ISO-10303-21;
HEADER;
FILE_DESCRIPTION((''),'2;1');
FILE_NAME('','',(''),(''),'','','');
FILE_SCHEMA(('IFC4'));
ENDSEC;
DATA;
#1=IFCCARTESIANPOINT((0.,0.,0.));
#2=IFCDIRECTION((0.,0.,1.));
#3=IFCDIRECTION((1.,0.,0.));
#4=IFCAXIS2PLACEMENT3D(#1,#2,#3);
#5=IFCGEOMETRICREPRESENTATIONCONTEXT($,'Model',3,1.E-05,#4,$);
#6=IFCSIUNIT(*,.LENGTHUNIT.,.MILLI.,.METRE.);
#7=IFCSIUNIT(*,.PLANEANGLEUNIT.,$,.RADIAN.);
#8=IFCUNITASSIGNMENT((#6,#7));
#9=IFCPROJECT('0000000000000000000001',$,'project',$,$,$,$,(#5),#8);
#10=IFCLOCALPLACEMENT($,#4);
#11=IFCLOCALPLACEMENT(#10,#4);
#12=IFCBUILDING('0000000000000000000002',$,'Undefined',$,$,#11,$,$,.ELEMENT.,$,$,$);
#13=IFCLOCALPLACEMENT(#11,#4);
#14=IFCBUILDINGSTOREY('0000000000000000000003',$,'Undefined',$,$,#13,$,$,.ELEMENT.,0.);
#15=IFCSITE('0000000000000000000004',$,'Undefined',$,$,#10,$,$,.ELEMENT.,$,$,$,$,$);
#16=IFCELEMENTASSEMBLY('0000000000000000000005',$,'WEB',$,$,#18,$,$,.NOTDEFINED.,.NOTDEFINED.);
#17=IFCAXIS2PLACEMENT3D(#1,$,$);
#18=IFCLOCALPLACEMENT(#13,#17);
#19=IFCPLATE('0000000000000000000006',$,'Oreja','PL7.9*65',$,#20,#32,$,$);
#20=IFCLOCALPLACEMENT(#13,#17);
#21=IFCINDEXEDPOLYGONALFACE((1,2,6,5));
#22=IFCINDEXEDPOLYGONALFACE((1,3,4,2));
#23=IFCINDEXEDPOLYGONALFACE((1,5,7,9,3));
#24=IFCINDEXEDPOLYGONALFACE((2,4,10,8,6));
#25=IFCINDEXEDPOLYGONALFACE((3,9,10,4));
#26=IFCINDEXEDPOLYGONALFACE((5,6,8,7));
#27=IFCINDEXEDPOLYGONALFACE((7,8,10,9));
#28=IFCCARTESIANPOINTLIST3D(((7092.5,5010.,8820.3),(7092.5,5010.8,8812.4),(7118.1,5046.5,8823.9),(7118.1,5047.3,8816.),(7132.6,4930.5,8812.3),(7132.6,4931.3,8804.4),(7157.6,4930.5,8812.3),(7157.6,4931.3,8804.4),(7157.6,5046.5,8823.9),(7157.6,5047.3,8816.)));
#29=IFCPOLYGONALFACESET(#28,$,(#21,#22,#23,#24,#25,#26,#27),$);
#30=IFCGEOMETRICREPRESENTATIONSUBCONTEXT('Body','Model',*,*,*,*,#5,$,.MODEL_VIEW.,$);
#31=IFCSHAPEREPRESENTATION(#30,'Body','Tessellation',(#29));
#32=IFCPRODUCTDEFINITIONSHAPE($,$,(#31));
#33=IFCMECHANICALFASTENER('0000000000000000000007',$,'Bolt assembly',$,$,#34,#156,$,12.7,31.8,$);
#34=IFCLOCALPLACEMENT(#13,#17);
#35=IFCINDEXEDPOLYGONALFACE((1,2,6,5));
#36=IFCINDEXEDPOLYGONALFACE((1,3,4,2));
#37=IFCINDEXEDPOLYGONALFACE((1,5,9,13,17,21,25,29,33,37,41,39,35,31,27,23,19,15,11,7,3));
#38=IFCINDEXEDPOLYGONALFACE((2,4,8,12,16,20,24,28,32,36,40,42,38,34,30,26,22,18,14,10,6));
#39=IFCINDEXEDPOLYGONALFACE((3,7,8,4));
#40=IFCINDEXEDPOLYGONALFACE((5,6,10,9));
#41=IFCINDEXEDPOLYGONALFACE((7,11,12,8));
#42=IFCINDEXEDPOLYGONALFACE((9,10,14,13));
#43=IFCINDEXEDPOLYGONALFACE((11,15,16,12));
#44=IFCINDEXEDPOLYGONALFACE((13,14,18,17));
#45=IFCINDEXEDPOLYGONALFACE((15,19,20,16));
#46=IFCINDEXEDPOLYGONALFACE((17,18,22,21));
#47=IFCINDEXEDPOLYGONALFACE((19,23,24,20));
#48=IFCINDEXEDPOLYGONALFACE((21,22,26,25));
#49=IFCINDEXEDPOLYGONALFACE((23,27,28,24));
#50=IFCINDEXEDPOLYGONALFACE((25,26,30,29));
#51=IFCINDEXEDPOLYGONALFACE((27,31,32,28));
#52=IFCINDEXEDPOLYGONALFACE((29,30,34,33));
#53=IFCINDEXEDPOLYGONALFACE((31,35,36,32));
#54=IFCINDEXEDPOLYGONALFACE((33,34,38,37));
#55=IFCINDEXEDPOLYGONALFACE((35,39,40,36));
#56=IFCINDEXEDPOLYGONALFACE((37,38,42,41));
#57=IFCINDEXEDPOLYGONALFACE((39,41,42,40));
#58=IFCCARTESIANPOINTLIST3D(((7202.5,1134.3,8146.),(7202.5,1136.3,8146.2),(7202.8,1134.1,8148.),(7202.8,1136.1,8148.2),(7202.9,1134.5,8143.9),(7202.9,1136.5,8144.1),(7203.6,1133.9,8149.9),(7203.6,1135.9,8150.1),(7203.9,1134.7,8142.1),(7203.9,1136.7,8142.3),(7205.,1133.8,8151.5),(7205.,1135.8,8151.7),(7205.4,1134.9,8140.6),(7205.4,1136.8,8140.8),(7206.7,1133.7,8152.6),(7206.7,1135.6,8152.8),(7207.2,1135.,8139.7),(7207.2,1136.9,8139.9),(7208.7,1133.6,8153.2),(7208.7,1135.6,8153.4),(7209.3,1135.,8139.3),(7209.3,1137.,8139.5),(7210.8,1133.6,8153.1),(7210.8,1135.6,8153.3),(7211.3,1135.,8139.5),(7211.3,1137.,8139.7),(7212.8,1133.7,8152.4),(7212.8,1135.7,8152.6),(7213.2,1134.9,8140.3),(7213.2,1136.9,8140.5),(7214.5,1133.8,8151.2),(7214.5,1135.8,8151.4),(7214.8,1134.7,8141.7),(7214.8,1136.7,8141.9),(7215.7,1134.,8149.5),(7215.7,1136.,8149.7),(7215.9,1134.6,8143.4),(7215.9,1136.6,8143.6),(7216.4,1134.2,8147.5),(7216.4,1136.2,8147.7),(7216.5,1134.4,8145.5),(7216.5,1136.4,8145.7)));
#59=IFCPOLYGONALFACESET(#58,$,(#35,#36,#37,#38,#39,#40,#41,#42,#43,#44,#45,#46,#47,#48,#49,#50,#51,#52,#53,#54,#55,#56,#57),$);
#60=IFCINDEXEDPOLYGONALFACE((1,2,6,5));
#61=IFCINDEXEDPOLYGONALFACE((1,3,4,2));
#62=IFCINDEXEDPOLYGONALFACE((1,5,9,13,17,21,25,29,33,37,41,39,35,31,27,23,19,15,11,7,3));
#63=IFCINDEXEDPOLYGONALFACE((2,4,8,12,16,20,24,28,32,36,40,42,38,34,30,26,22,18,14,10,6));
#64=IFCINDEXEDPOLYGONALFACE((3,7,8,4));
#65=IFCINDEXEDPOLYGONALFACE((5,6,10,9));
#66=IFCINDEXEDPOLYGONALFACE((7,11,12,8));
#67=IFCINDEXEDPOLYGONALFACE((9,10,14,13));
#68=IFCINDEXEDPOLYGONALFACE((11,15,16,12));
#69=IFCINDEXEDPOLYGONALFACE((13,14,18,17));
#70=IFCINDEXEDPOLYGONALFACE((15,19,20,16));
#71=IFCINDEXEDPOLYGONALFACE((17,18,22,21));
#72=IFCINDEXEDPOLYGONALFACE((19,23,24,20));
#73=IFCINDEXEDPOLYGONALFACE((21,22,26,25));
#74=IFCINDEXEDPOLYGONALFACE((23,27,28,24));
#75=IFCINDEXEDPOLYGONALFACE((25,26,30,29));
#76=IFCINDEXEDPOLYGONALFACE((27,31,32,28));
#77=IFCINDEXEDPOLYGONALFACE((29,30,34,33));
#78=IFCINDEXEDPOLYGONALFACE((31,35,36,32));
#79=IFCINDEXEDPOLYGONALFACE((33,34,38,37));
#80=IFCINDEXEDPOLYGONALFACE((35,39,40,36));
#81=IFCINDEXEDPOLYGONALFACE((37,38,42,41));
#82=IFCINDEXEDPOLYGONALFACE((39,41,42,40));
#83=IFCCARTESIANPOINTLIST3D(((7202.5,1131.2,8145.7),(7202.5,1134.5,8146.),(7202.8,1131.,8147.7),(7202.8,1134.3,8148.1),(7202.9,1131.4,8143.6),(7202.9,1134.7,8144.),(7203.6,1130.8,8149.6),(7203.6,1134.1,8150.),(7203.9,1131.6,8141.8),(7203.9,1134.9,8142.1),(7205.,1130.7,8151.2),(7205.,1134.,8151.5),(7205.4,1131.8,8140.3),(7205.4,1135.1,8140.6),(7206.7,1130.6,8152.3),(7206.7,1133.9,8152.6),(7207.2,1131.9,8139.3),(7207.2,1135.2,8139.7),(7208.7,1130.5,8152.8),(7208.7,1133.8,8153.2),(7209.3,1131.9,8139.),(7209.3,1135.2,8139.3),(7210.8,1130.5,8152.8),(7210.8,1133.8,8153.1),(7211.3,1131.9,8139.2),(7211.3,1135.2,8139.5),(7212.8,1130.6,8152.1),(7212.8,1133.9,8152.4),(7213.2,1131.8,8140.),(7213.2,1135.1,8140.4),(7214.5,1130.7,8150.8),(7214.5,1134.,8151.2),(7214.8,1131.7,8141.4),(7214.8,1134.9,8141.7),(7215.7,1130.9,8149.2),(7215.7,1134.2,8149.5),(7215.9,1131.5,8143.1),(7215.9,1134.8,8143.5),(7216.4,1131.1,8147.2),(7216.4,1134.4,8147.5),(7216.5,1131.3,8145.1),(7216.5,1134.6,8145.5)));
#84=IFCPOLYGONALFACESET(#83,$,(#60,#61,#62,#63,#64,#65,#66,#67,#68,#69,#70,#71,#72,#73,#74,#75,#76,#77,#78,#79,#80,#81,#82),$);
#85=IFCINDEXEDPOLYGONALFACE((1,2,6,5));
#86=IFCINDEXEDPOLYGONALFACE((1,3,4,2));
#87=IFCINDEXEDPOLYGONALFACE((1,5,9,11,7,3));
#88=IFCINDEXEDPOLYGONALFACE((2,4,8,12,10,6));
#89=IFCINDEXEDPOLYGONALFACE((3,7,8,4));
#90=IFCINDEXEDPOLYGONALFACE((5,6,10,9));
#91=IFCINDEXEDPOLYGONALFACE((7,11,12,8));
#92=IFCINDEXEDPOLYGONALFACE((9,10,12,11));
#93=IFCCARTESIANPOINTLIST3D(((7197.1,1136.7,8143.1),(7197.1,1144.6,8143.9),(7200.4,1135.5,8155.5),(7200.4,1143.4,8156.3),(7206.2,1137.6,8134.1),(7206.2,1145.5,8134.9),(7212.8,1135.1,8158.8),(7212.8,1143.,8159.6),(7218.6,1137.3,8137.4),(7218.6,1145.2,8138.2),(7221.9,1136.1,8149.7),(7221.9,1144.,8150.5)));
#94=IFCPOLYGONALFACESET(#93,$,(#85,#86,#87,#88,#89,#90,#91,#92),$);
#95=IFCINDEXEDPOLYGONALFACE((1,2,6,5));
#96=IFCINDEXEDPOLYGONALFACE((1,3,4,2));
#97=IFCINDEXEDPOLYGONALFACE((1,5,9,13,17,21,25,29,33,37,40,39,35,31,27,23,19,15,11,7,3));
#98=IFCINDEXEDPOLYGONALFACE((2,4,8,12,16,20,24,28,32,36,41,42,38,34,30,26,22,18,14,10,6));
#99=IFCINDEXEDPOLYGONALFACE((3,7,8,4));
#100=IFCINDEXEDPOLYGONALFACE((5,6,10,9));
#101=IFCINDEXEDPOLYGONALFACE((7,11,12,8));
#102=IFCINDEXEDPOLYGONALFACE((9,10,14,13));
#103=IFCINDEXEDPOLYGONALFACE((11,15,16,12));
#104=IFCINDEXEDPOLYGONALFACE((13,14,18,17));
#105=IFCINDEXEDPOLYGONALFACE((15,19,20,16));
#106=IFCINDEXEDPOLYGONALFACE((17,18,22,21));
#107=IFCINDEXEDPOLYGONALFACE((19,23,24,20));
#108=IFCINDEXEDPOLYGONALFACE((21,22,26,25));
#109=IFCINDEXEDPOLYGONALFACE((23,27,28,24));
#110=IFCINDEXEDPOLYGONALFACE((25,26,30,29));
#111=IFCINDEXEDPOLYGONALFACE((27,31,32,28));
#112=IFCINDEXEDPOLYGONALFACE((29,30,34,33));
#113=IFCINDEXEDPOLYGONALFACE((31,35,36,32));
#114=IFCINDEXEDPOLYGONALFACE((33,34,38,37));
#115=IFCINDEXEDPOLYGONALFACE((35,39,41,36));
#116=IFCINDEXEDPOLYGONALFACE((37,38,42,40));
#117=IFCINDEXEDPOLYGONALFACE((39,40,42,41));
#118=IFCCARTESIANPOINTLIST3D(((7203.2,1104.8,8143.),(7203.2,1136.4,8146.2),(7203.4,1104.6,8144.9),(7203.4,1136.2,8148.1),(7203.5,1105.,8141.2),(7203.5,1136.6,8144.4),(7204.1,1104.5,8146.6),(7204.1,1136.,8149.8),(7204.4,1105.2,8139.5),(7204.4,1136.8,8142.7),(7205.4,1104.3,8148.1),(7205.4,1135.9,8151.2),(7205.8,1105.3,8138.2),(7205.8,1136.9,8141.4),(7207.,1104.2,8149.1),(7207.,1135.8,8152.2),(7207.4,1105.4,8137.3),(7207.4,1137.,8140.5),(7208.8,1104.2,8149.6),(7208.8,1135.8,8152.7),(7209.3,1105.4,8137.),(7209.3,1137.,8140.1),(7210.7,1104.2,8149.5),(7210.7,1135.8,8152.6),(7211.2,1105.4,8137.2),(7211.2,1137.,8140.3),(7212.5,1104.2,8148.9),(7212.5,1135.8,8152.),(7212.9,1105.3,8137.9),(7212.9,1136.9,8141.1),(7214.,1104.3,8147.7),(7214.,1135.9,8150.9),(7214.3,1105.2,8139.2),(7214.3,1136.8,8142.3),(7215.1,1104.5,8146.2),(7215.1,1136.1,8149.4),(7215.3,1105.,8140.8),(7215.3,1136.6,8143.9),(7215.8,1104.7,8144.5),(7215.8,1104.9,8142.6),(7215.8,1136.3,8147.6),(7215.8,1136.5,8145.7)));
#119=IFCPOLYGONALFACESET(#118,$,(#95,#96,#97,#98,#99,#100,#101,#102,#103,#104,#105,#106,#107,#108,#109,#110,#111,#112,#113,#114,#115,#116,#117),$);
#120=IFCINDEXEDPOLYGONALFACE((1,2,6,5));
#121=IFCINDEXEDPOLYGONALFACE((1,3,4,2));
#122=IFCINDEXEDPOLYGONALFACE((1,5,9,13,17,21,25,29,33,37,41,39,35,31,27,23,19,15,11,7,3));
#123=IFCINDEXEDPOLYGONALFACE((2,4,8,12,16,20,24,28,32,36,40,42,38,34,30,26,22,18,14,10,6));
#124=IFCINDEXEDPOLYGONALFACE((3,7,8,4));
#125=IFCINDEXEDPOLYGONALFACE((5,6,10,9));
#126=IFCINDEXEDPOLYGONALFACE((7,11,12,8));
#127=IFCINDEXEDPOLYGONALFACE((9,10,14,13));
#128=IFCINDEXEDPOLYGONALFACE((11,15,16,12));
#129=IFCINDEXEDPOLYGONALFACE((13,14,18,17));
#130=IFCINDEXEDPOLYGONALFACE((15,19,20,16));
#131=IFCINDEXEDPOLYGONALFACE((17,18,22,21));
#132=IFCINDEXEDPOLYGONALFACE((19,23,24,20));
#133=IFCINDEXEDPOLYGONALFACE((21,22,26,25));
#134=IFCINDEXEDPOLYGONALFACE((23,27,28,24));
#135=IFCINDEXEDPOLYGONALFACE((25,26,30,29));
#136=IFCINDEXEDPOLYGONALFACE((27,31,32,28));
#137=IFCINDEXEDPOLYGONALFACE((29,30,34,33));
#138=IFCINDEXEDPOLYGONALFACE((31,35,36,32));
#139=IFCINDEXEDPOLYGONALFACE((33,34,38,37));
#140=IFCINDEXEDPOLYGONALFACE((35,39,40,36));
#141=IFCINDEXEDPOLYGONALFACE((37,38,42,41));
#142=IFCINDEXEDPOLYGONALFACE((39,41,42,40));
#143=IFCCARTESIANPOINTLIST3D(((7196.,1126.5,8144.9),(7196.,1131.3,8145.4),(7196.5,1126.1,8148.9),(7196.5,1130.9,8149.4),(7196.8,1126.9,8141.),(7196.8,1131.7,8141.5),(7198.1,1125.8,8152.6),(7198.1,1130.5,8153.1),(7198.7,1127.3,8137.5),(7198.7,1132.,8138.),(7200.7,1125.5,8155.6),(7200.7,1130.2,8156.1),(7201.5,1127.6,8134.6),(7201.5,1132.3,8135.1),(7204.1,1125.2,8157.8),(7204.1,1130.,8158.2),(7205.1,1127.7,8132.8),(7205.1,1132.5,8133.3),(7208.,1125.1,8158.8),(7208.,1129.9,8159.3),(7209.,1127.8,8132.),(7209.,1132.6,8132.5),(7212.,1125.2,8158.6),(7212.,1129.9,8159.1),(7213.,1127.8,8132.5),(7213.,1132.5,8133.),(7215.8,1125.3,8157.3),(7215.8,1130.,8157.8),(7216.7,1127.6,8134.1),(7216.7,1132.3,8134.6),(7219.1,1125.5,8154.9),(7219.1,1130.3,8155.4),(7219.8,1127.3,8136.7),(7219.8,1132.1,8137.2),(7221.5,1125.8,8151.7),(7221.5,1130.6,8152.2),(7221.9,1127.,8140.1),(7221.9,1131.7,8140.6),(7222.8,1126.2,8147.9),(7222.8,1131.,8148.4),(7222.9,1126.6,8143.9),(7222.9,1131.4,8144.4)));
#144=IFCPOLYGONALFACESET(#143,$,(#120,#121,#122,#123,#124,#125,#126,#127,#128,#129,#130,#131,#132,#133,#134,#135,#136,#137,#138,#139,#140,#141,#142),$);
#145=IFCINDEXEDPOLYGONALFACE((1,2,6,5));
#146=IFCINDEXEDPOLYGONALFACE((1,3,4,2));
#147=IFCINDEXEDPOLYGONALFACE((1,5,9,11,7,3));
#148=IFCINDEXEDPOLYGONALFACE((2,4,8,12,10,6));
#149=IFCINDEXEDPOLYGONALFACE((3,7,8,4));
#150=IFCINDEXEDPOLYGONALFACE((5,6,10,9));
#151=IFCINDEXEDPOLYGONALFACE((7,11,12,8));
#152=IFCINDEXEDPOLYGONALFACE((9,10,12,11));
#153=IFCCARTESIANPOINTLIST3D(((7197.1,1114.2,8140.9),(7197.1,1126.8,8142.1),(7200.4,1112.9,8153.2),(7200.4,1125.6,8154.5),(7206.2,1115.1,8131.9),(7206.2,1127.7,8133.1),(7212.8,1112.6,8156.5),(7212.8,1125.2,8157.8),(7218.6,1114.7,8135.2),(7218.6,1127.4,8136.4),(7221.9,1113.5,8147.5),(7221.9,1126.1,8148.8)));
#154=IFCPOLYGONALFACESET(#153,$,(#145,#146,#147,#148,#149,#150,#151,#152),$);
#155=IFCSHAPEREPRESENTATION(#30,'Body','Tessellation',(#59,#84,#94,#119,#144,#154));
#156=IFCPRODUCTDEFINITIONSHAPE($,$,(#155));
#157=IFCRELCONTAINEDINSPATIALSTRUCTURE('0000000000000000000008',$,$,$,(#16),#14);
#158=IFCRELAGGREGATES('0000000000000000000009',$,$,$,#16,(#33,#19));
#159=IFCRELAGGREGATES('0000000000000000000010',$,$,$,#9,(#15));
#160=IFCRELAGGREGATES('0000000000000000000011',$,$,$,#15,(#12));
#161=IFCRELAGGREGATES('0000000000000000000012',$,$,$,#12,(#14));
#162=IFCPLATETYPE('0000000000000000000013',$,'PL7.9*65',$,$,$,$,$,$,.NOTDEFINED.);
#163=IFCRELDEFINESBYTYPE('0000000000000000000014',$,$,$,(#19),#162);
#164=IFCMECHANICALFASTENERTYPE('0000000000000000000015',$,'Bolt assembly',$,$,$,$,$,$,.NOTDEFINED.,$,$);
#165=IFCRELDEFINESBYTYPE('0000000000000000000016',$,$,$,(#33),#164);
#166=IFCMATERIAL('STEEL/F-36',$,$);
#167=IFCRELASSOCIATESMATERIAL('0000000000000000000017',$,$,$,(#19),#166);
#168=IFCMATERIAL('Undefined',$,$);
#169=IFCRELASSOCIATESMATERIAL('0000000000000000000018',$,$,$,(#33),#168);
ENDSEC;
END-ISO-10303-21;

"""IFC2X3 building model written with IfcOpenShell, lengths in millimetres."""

from ifc_helpers import new_model, si_unit, frame, origin_with_axes, origin_2d_with_axis, place, context, subcontext, project, spatial, polyline, circle, outline, extrude, source, transform, mapped, material, type_object, element, aggregate, save


model = new_model("IFC2X3")

# Units and contexts
model_context = context("Model", 3, precision=1e-05, world=origin_with_axes())
body_context = subcontext(model_context, "Body", "Model", "MODEL_VIEW")
ifc_project = project(units=[si_unit("LENGTHUNIT", "METRE", prefix="MILLI"), si_unit("PLANEANGLEUNIT", "RADIAN")], contexts=[model_context])

# Site, building, storey
site_placement = place(None, origin_with_axes())
site = spatial("IfcSite", under=ifc_project, at=site_placement, Name="Undefined", CompositionType="ELEMENT")
building_placement = place(site_placement, origin_with_axes())
building = spatial("IfcBuilding", under=site, at=building_placement, Name="Undefined", CompositionType="ELEMENT")
storey_placement = place(building_placement, origin_with_axes())
storey = spatial("IfcBuildingStorey", under=building, at=storey_placement, Name="Undefined", CompositionType="ELEMENT", Elevation=0.0)

# Element assembly, plate, mechanical fastener
assembly_1_placement = place(storey_placement, origin_with_axes())
assembly_1 = element("IfcElementAssembly", 1, at=assembly_1_placement, inside=storey, Name="WEB", AssemblyPlace="NOTDEFINED", PredefinedType="NOTDEFINED")
ifc_material_1 = material(Name="STEEL/F-36")
plate_type_1 = type_object("IfcPlateType", Name="PL7.9*65", PredefinedType="NOTDEFINED")
plate_1_placement = place(assembly_1_placement, frame((7157.6, 4930.9, 8808.4), z_axis=(0.0, -0.099505, 0.995037), x_axis=(0.0, 0.995037, 0.099505)))
plate_1 = element("IfcPlate", 2, at=plate_1_placement, type_object=plate_type_1, material=ifc_material_1, Name="Oreja", Description="PL7.9*65", context=body_context, shape_type="SweptSolid", body=[
    extrude(outline(polyline([(0.0, 0.0), (116.6, 0.0), (116.6, 39.5), (79.9, 65.1), (0.0, 25.0), (0.0, 0.0)])), frame((0.0, 0.0, -4.0), z_axis=(0.0, 0.0, 1.0), x_axis=(1.0, 0.0, 0.0)), (0.0, 0.0, 1.0), 7.9),
])
ifc_material_2 = material(Name="Undefined")
mechanical_fastener_type = type_object("IfcMechanicalFastenerType", Name="Bolt assembly")
shared_shape_1 = source(origin_with_axes(), body_context, "Body", "SweptSolid", [
    extrude(circle(Radius=7.0, at=origin_2d_with_axis()), frame((0.0, -1.9, 0.0), z_axis=(0.0, 1.0, 0.0), x_axis=(1.0, 0.0, 0.0)), (0.0, 0.0, 1.0), 2.0),
    extrude(circle(Radius=7.0, at=origin_2d_with_axis()), frame((0.0, -0.1, 0.0), z_axis=(0.0, 1.0, 0.0), x_axis=(1.0, 0.0, 0.0)), (0.0, 0.0, 1.0), 3.3),
    extrude(outline(polyline([(11.1, -6.4), (11.1, 6.4), (0.0, 12.8), (-11.1, 6.4), (-11.1, -6.4), (0.0, -12.8), (11.1, -6.4)])), frame((0.0, -9.9, 0.0), z_axis=(0.0, 1.0, 0.0), x_axis=(1.0, 0.0, 0.0)), (0.0, 0.0, 1.0), 7.9),
    extrude(circle(Radius=6.3, at=origin_2d_with_axis()), frame((0.0, -2.0, 0.0), z_axis=(0.0, 1.0, 0.0), x_axis=(1.0, 0.0, 0.0)), (0.0, 0.0, 1.0), 31.8),
    extrude(circle(Radius=13.5, at=origin_2d_with_axis()), frame((0.0, 3.2, 0.0), z_axis=(0.0, 1.0, 0.0), x_axis=(1.0, 0.0, 0.0)), (0.0, 0.0, 1.0), 4.8),
    extrude(outline(polyline([(11.1, -6.4), (11.1, 6.4), (0.0, 12.8), (-11.1, 6.4), (-11.1, -6.4), (0.0, -12.8), (11.1, -6.4)])), frame((0.0, 8.0, 0.0), z_axis=(0.0, 1.0, 0.0), x_axis=(1.0, 0.0, 0.0)), (0.0, 0.0, 1.0), 12.7),
])
mechanical_fastener_1_placement = place(assembly_1_placement, frame((7209.5, 1134.4, 8146.2), z_axis=(0.707107, 0.07036, -0.703598), x_axis=(0.707107, -0.07036, 0.703598)))
mechanical_fastener_1 = element("IfcMechanicalFastener", 3, at=mechanical_fastener_1_placement, type_object=mechanical_fastener_type, material=ifc_material_2, Name="Bolt assembly", NominalDiameter=12.7, NominalLength=31.8, context=body_context, shape_type="MappedRepresentation", body=[
    mapped(shared_shape_1, transform((0.0, 0.0, 0.0))),
])
aggregate(assembly_1, [mechanical_fastener_1, plate_1])

save(model, "model.ifc")
